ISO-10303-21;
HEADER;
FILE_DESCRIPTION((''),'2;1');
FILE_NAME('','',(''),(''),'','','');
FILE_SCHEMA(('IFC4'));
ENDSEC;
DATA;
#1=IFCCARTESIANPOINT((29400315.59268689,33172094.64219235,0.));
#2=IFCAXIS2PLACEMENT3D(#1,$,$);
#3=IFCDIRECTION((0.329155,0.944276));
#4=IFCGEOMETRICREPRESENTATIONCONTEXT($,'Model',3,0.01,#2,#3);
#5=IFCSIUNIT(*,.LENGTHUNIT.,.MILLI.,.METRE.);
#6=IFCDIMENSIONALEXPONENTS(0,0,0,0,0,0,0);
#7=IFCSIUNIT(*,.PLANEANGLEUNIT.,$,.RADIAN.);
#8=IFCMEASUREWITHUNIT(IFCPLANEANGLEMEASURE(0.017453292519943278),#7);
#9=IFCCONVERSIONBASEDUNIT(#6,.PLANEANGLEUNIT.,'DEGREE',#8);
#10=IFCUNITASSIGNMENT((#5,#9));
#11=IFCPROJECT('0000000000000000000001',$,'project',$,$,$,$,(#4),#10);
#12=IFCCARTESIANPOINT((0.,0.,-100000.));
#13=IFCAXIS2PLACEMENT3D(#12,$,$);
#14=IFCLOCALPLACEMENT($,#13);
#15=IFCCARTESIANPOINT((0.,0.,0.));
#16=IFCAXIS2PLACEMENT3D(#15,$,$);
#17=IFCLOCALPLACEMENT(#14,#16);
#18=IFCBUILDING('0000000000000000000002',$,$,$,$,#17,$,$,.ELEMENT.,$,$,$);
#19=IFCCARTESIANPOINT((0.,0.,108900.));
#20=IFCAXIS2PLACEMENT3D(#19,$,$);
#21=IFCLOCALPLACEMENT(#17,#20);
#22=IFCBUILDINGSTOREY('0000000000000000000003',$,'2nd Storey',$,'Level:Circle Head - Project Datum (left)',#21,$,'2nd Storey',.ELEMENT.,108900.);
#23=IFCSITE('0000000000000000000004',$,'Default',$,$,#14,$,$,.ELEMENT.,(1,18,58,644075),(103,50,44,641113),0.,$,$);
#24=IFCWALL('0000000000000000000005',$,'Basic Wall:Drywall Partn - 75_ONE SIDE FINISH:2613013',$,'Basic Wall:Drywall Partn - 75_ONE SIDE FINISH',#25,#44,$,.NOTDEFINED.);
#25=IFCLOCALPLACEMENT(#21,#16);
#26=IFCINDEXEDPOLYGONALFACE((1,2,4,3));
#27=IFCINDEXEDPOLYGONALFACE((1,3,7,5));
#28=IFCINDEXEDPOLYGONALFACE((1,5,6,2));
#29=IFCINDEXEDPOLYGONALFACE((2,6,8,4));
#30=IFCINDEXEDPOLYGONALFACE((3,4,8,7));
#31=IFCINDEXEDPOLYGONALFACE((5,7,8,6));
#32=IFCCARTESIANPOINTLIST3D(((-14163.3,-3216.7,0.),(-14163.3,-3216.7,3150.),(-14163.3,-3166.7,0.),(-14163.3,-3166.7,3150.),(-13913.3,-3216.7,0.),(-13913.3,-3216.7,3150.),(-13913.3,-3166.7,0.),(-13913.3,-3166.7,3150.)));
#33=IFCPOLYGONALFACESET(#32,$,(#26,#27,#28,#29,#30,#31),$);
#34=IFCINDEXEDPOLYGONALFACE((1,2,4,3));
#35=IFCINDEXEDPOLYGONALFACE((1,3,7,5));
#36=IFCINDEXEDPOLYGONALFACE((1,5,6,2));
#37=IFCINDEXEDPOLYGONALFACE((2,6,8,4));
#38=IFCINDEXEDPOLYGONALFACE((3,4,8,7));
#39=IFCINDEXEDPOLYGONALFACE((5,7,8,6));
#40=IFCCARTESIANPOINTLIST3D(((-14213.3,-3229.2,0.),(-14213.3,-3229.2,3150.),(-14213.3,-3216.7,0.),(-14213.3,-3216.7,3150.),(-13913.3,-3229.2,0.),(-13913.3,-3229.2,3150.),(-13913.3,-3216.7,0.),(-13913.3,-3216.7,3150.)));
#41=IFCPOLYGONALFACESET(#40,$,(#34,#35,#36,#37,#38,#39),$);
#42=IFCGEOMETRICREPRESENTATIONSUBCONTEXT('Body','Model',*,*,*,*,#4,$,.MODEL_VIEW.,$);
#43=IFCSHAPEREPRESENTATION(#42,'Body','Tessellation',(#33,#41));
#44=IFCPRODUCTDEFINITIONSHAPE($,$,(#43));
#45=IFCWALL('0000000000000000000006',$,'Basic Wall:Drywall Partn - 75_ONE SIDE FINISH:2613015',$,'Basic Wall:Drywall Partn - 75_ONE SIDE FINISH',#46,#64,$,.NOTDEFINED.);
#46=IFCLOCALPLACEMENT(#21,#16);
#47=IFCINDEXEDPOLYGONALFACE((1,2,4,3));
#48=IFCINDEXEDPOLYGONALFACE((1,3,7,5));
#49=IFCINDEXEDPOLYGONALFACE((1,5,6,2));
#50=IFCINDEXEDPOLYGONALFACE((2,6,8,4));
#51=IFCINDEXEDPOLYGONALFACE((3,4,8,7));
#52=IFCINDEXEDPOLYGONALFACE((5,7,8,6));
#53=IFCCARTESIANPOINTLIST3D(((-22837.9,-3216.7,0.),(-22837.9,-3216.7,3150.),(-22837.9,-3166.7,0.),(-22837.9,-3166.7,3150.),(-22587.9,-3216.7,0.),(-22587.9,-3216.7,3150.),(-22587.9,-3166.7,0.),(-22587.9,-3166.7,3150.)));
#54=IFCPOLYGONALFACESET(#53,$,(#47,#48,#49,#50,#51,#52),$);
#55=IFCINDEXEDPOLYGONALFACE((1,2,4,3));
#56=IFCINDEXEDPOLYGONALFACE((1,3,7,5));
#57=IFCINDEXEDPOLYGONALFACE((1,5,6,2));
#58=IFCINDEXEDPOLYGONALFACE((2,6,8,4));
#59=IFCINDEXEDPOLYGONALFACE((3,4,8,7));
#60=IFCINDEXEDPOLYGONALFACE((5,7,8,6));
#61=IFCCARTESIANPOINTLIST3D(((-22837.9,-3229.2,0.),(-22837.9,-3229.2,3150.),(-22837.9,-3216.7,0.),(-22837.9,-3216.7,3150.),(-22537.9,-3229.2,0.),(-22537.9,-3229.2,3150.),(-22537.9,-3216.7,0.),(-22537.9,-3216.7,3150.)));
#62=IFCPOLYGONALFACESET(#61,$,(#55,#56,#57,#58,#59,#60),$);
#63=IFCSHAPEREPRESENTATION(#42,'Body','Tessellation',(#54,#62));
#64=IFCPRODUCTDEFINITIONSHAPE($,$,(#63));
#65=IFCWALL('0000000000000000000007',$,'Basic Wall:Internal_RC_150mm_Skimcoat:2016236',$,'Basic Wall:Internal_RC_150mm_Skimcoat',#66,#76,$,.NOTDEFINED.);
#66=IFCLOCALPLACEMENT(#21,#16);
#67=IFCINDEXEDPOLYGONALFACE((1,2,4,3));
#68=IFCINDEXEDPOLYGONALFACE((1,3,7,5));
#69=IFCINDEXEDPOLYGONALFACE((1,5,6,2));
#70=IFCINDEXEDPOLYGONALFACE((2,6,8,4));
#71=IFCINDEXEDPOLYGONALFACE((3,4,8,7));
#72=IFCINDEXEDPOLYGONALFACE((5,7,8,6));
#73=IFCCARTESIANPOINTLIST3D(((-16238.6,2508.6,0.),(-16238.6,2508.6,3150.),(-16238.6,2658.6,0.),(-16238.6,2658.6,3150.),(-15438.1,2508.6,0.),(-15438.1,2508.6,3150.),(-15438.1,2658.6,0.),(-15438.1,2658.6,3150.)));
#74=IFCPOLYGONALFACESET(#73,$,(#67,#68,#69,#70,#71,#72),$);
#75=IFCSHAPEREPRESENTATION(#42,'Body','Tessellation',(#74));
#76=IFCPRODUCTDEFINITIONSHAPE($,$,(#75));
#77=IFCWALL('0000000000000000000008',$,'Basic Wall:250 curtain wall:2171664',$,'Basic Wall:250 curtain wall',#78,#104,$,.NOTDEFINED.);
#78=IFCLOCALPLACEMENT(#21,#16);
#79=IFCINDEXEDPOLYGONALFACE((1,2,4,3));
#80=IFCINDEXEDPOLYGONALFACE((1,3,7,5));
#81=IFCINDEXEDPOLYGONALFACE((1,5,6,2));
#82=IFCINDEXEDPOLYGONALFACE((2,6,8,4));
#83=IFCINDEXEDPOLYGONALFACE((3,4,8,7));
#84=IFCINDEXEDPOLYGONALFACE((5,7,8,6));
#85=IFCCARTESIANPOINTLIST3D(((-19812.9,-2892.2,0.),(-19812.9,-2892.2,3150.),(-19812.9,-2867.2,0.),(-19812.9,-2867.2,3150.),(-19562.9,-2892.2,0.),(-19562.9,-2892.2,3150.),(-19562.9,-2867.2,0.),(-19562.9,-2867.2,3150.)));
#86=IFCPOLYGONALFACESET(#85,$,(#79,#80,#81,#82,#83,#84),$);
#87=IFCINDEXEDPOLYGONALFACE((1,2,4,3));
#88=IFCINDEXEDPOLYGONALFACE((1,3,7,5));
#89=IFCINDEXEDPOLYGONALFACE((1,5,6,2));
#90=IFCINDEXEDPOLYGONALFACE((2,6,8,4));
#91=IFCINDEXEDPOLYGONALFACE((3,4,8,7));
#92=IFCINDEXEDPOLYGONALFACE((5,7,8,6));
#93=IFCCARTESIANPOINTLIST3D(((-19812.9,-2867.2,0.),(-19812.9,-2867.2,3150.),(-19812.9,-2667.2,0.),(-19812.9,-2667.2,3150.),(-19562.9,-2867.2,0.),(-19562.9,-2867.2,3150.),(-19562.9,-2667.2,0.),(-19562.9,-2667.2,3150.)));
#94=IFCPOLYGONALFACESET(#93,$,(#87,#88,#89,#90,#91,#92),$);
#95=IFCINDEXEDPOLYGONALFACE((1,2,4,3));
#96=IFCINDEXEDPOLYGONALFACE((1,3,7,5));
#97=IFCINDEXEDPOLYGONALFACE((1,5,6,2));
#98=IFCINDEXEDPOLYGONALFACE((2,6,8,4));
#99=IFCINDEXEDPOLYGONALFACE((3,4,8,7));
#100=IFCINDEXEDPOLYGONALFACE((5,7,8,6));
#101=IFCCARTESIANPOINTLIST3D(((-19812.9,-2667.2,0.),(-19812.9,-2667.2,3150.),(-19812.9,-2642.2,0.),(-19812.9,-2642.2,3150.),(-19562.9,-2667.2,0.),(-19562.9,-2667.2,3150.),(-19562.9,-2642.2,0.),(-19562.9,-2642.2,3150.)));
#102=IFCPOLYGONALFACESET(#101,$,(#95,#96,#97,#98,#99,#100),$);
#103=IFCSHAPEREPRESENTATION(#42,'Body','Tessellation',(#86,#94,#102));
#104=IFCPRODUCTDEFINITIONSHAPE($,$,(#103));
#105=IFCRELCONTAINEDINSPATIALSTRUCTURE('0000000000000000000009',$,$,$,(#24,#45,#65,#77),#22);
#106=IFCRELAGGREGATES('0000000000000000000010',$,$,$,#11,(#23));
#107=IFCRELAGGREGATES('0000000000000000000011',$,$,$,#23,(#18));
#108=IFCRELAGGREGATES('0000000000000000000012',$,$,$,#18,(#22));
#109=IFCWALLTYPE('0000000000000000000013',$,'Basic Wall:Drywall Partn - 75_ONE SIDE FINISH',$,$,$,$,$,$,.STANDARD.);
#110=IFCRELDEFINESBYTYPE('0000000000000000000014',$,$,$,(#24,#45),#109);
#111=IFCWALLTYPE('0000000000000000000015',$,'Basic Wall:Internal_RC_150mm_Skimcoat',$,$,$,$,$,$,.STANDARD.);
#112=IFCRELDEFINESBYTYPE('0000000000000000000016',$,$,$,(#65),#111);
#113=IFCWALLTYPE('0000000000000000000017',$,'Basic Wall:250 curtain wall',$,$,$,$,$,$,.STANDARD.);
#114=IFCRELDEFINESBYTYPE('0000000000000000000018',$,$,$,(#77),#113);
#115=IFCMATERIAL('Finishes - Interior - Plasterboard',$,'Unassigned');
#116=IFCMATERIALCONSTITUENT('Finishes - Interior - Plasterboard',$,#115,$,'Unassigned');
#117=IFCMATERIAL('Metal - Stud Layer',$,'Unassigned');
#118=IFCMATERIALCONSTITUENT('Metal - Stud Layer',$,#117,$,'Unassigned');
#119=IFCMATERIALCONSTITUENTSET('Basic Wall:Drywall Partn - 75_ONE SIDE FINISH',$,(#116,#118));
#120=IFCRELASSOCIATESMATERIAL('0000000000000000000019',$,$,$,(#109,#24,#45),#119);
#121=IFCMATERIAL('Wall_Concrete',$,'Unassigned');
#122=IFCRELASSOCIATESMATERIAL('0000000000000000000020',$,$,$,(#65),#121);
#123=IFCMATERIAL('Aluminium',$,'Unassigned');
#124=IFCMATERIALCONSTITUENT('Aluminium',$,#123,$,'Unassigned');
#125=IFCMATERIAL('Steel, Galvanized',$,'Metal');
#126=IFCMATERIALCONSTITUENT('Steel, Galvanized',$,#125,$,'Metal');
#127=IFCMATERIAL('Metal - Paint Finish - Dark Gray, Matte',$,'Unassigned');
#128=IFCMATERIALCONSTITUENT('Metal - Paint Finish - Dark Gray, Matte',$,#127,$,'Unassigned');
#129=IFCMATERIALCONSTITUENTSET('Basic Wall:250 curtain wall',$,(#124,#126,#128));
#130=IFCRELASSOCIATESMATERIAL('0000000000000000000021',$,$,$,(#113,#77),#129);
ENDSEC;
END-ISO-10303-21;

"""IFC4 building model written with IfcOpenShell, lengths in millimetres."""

from ifc_helpers import new_model, entity, si_unit, converted_unit, direction, frame, origin, place, context, subcontext, project, spatial, indexed_curve, outline, extrude, material, constituent, constituent_set, type_object, element, save


model = new_model("IFC4")

# Units and contexts
model_context = context("Model", 3, precision=0.01, world=frame((29400315.59268689, 33172094.64219235, 0.0)), true_north=direction((0.329155, 0.944276)))
body_context = subcontext(model_context, "Body", "Model", "MODEL_VIEW")
ifc_project = project(units=[si_unit("LENGTHUNIT", "METRE", prefix="MILLI"), converted_unit("PLANEANGLEUNIT", "DEGREE", entity("IfcPlaneAngleMeasure", 0.017453292519943278), si_unit("PLANEANGLEUNIT", "RADIAN"), dimensions=[0, 0, 0, 0, 0, 0, 0])], contexts=[model_context])

# Site, building, storey
site_placement = place(None, frame((0.0, 0.0, -100000.0)))
site = spatial("IfcSite", under=ifc_project, at=site_placement, Name="Default", CompositionType="ELEMENT", RefLatitude=(1, 18, 58, 644075), RefLongitude=(103, 50, 44, 641113), RefElevation=0.0)
building_placement = place(site_placement, origin())
building = spatial("IfcBuilding", under=site, at=building_placement, CompositionType="ELEMENT")
storey_placement = place(building_placement, frame((0.0, 0.0, 108900.0)))
storey = spatial("IfcBuildingStorey", under=building, at=storey_placement, Name="2nd Storey", ObjectType="Level:Circle Head - Project Datum (left)", LongName="2nd Storey", CompositionType="ELEMENT", Elevation=108900.0)

# Shared definitions
ifc_material_1 = material(Name="Aluminium", Category="Unassigned")

# Walls
ifc_material_2 = material(Name="Wall_Concrete", Category="Unassigned")
ifc_material_3 = material(Name="Finishes - Interior - Plasterboard", Category="Unassigned")
ifc_constituent_1 = constituent(ifc_material_3, Name="Finishes - Interior - Plasterboard", Category="Unassigned")
ifc_material_4 = material(Name="Metal - Stud Layer", Category="Unassigned")
ifc_constituent_2 = constituent(ifc_material_4, Name="Metal - Stud Layer", Category="Unassigned")
ifc_constituent_set_1 = constituent_set(constituents=[ifc_constituent_1, ifc_constituent_2], Name="Basic Wall:Drywall Partn - 75_ONE SIDE FINISH")
wall_type_1 = type_object("IfcWallType", Name="Basic Wall:Drywall Partn - 75_ONE SIDE FINISH", PredefinedType="STANDARD", material=ifc_constituent_set_1)
wall_1_placement = place(storey_placement, frame((-14163.3, -3198.0, 0.0)))
element("IfcWall", 1, at=wall_1_placement, inside=storey, type_object=wall_type_1, material=ifc_constituent_set_1, Name="Basic Wall:Drywall Partn - 75_ONE SIDE FINISH:2613013", ObjectType="Basic Wall:Drywall Partn - 75_ONE SIDE FINISH", PredefinedType="NOTDEFINED", context=body_context, shape_type="SweptSolid", body=[
    extrude(outline(indexed_curve([(-25.0, -125.0), (25.0, -125.0), (25.0, 125.0), (-25.0, 125.0), (-25.0, -125.0)], self_intersect=False)), frame((125.0, 6.3, 0.0), z_axis=(0.0, 0.0, 1.0), x_axis=(0.0, -1.0, 0.0)), (0.0, 0.0, 1.0), 3150.0),
    extrude(outline(indexed_curve([(-6.3, -150.0), (6.2, -150.0), (6.3, 150.0), (-6.2, 150.0), (-6.3, -150.0)], self_intersect=False)), frame((100.0, -25.0, 0.0), z_axis=(0.0, 0.0, 1.0), x_axis=(0.0, 1.0, 0.0)), (0.0, 0.0, 1.0), 3150.0),
])
wall_2_placement = place(storey_placement, frame((-22587.9, -3198.0, 0.0), z_axis=(0.0, 0.0, 1.0), x_axis=(-1.0, 0.0, 0.0)))
element("IfcWall", 2, at=wall_2_placement, inside=storey, type_object=wall_type_1, material=ifc_constituent_set_1, Name="Basic Wall:Drywall Partn - 75_ONE SIDE FINISH:2613015", ObjectType="Basic Wall:Drywall Partn - 75_ONE SIDE FINISH", PredefinedType="NOTDEFINED", context=body_context, shape_type="SweptSolid", body=[
    extrude(outline(indexed_curve([(-25.0, -125.0), (25.0, -125.0), (25.0, 125.0), (-25.0, 125.0), (-25.0, -125.0)], self_intersect=False)), frame((125.0, -6.2, 0.0), z_axis=(0.0, 0.0, 1.0), x_axis=(0.0, 1.0, 0.0)), (0.0, 0.0, 1.0), 3150.0),
    extrude(outline(indexed_curve([(-6.3, -150.0), (6.2, -150.0), (6.3, 150.0), (-6.2, 150.0), (-6.3, -150.0)], self_intersect=False)), frame((100.0, 25.0, 0.0), z_axis=(0.0, 0.0, 1.0), x_axis=(0.0, -1.0, 0.0)), (0.0, 0.0, 1.0), 3150.0),
])
wall_type_2 = type_object("IfcWallType", Name="Basic Wall:Internal_RC_150mm_Skimcoat", PredefinedType="STANDARD")
wall_3_placement = place(storey_placement, frame((-16238.6, 2583.6, 0.0)))
element("IfcWall", 3, at=wall_3_placement, inside=storey, type_object=wall_type_2, material=ifc_material_2, Name="Basic Wall:Internal_RC_150mm_Skimcoat:2016236", ObjectType="Basic Wall:Internal_RC_150mm_Skimcoat", PredefinedType="NOTDEFINED", context=body_context, shape_type="SweptSolid", body=[
    extrude(outline(indexed_curve([(800.5, 75.0), (0.0, 75.0), (0.0, -75.0), (800.5, -75.0), (800.5, 75.0)], self_intersect=False)), origin(), (0.0, 0.0, 1.0), 3150.0),
])
ifc_constituent_3 = constituent(ifc_material_1, Name="Aluminium", Category="Unassigned")
ifc_material_5 = material(Name="Steel, Galvanized", Category="Metal")
ifc_constituent_4 = constituent(ifc_material_5, Name="Steel, Galvanized", Category="Metal")
ifc_material_6 = material(Name="Metal - Paint Finish - Dark Gray, Matte", Category="Unassigned")
ifc_constituent_5 = constituent(ifc_material_6, Name="Metal - Paint Finish - Dark Gray, Matte", Category="Unassigned")
ifc_constituent_set_2 = constituent_set(constituents=[ifc_constituent_3, ifc_constituent_4, ifc_constituent_5], Name="Basic Wall:250 curtain wall")
wall_type_3 = type_object("IfcWallType", Name="Basic Wall:250 curtain wall", PredefinedType="STANDARD", material=ifc_constituent_set_2)
wall_4_placement = place(storey_placement, frame((-19562.9, -2767.2, 0.0), z_axis=(0.0, 0.0, 1.0), x_axis=(-1.0, 0.0, 0.0)))
element("IfcWall", 4, at=wall_4_placement, inside=storey, type_object=wall_type_3, material=ifc_constituent_set_2, Name="Basic Wall:250 curtain wall:2171664", ObjectType="Basic Wall:250 curtain wall", PredefinedType="NOTDEFINED", context=body_context, shape_type="SweptSolid", body=[
    extrude(outline(indexed_curve([(-12.5, -125.0), (12.5, -125.0), (12.5, 125.0), (-12.5, 125.0), (-12.5, -125.0)], self_intersect=False)), frame((125.0, 112.5, 0.0), z_axis=(0.0, 0.0, 1.0), x_axis=(0.0, -1.0, 0.0)), (0.0, 0.0, 1.0), 3150.0),
    extrude(outline(indexed_curve([(-125.0, -100.0), (125.0, -100.0), (125.0, 100.0), (-125.0, 100.0), (-125.0, -100.0)], self_intersect=False)), frame((125.0, 0.0, 0.0)), (0.0, 0.0, 1.0), 3150.0),
    extrude(outline(indexed_curve([(-12.5, -125.0), (12.5, -125.0), (12.5, 125.0), (-12.5, 125.0), (-12.5, -125.0)], self_intersect=False)), frame((125.0, -112.5, 0.0), z_axis=(0.0, 0.0, 1.0), x_axis=(0.0, 1.0, 0.0)), (0.0, 0.0, 1.0), 3150.0),
])

save(model, "model.ifc")
